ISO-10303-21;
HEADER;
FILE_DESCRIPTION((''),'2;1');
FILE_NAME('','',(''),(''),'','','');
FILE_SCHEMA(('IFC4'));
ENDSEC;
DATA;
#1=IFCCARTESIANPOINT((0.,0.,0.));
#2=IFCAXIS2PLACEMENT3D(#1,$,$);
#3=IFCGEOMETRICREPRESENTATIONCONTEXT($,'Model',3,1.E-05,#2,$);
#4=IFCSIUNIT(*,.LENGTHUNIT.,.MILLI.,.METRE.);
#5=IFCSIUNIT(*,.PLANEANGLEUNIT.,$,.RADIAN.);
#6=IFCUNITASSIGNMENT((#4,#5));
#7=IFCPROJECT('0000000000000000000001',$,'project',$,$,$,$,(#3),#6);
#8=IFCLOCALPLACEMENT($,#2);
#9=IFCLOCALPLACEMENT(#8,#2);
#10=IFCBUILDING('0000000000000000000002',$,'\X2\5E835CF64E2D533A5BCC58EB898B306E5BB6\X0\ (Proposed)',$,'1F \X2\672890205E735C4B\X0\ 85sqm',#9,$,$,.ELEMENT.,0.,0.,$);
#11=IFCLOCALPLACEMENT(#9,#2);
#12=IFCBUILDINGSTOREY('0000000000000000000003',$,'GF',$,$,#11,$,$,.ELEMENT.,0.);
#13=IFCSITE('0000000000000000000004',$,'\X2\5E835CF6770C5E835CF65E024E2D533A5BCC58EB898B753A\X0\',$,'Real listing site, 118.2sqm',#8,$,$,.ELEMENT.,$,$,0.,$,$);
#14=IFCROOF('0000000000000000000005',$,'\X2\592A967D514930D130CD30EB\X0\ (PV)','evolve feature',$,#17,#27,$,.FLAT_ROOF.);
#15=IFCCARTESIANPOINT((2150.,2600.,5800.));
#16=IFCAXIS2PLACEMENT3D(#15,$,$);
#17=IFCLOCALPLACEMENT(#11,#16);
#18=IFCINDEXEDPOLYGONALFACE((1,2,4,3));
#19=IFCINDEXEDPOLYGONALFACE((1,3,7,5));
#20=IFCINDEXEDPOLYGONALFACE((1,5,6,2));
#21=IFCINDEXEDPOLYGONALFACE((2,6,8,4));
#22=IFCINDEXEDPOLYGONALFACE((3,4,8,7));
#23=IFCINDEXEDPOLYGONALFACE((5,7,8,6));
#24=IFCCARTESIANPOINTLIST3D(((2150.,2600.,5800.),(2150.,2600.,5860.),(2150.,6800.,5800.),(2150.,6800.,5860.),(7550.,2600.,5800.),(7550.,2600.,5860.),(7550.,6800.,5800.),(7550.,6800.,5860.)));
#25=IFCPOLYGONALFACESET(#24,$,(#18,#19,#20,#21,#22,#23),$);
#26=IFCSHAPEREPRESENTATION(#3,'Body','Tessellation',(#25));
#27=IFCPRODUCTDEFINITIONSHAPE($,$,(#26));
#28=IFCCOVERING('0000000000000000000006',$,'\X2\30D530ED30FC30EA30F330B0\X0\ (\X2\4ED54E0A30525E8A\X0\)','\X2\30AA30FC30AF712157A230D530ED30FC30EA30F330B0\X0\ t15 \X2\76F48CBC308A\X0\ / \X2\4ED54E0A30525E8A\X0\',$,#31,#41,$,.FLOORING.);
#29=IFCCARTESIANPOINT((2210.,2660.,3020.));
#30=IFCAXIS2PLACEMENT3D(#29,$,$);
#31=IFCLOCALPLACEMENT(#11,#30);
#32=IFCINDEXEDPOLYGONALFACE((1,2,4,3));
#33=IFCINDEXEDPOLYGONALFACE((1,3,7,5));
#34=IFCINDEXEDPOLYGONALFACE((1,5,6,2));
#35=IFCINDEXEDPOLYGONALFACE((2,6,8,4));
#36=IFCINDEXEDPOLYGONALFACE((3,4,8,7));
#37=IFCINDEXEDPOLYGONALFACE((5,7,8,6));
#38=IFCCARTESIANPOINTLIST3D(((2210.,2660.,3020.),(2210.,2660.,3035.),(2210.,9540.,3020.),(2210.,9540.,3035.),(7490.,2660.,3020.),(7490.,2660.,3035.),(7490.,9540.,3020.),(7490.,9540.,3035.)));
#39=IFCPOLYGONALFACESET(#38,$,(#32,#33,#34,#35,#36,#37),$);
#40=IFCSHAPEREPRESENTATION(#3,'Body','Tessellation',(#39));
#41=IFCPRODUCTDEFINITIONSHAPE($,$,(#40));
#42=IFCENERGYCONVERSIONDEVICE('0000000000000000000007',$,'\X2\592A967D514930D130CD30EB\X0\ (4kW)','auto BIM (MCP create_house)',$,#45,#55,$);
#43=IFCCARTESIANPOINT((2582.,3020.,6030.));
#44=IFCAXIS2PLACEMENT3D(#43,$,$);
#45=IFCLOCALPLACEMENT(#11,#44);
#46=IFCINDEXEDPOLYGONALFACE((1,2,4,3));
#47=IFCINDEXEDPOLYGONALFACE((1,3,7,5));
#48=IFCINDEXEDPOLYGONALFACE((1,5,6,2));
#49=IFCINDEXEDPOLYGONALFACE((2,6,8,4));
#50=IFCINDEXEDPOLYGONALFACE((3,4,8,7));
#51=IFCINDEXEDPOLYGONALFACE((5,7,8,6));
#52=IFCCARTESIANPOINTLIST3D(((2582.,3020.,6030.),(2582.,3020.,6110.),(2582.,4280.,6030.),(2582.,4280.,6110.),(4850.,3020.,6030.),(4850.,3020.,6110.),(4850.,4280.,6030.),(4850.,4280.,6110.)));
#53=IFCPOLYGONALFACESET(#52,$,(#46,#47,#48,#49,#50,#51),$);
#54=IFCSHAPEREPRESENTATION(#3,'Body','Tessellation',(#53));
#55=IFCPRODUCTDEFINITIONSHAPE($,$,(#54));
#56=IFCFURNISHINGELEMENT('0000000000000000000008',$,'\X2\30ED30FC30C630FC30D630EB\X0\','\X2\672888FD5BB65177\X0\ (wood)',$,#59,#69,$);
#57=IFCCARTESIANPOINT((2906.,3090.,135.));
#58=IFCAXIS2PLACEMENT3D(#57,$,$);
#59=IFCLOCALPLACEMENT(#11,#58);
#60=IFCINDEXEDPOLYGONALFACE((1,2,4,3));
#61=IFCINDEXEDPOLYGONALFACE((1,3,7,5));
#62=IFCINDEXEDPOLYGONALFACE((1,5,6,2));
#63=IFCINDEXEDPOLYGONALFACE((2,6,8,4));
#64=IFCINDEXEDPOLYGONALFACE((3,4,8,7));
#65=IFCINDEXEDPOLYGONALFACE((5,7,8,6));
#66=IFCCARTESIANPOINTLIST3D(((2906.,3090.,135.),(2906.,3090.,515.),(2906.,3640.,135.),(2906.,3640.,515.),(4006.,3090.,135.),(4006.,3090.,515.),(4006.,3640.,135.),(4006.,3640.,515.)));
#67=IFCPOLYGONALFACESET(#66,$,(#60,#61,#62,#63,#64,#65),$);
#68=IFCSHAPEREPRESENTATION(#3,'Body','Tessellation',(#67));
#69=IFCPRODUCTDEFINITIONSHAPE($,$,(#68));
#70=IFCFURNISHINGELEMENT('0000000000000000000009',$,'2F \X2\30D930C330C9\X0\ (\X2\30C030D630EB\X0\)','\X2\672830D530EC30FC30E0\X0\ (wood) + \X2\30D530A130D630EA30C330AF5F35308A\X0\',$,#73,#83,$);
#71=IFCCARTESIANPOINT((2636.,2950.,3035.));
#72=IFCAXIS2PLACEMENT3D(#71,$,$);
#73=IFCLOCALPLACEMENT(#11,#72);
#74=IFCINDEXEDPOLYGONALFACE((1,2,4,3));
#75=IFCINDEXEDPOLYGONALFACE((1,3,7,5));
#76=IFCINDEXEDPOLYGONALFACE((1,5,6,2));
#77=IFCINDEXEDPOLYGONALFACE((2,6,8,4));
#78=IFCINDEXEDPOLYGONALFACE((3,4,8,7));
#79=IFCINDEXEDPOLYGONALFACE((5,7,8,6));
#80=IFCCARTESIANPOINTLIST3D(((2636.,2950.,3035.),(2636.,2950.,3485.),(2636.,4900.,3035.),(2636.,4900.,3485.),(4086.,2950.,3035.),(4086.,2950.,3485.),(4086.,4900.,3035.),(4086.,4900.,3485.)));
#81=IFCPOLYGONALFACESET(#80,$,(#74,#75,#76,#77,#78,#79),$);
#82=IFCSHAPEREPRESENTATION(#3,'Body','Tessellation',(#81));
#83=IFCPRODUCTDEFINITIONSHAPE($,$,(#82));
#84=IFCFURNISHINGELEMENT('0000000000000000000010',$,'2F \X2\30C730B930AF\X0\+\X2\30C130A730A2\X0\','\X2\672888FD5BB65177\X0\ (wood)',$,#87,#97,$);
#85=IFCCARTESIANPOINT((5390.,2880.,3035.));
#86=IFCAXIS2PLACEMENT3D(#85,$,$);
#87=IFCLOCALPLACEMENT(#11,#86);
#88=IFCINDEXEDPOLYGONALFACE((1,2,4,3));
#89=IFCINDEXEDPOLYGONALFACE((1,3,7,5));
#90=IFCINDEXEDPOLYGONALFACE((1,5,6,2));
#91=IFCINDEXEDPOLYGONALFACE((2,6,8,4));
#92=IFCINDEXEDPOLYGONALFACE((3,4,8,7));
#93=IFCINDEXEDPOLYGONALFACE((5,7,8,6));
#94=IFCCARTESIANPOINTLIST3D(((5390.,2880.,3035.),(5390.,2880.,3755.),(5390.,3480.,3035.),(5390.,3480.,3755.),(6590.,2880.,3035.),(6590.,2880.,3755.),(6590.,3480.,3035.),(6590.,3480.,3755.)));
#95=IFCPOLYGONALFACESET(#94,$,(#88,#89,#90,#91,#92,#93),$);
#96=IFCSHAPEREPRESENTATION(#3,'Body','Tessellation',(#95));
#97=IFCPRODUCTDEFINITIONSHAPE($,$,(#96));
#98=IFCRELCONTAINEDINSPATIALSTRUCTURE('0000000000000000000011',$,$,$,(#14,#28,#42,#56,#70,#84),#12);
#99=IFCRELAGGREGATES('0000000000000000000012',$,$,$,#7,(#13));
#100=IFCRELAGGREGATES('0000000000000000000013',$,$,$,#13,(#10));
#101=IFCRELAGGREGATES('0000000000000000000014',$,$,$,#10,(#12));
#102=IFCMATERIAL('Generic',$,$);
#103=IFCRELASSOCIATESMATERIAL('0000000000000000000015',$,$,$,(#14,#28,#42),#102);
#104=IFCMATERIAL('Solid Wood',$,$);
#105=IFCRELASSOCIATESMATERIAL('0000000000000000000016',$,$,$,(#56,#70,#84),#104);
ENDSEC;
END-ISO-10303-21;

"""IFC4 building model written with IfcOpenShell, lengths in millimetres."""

from ifc_helpers import new_model, si_unit, frame, frame_2d, origin, place, context, project, spatial, rectangle, extrude, material, element, save


model = new_model("IFC4")

# Units and contexts
model_context = context("Model", 3, precision=1e-05, world=origin())
ifc_project = project(units=[si_unit("LENGTHUNIT", "METRE", prefix="MILLI"), si_unit("PLANEANGLEUNIT", "RADIAN")], contexts=[model_context])

# Site, building, storey
site_placement = place(None, origin())
site = spatial("IfcSite", under=ifc_project, at=site_placement, Name="広島県広島市中区富士見町", ObjectType="Real listing site, 118.2sqm", CompositionType="ELEMENT", RefElevation=0.0)
building_placement = place(site_placement, origin())
building = spatial("IfcBuilding", under=site, at=building_placement, Name="広島中区富士見の家 (Proposed)", ObjectType="1F 木造平屋 85sqm", CompositionType="ELEMENT", ElevationOfRefHeight=0.0, ElevationOfTerrain=0.0)
storey_placement = place(building_placement, origin())
storey = spatial("IfcBuildingStorey", under=building, at=storey_placement, Name="GF", CompositionType="ELEMENT", Elevation=0.0)

# Shared definitions
ifc_material_1 = material(Name="Solid Wood")

# Shared definitions
ifc_material_2 = material(Name="Generic")

# Roof
roof_1_placement = place(storey_placement, frame((2150.0, 2600.0, 5800.0)))
element("IfcRoof", 1, at=roof_1_placement, inside=storey, material=ifc_material_2, Name="太陽光パネル (PV)", Description="evolve feature", PredefinedType="FLAT_ROOF", context=model_context, shape_type="SweptSolid", body=[
    extrude(rectangle(XDim=5400.0, YDim=4200.0, at=frame_2d((2700.0, 2100.0))), frame((2150.0, 2600.0, 5800.0)), (0.0, 0.0, 1.0), 60.0),
])

# Covering
covering_placement = place(storey_placement, frame((2210.0, 2660.0, 3020.0)))
element("IfcCovering", 2, at=covering_placement, inside=storey, material=ifc_material_2, Name="フローリング (仕上げ床)", Description="オーク無垢フローリング t15 直貼り / 仕上げ床", PredefinedType="FLOORING", context=model_context, shape_type="SweptSolid", body=[
    extrude(rectangle(XDim=5280.0, YDim=6880.0, at=frame_2d((2640.0, 3440.0))), frame((2210.0, 2660.0, 3020.0)), (0.0, 0.0, 1.0), 15.0),
])

# Energy conversion device
energy_conversion_device_placement = place(storey_placement, frame((2582.0, 3020.0, 6030.0)))
element("IfcEnergyConversionDevice", 3, at=energy_conversion_device_placement, inside=storey, material=ifc_material_2, Name="太陽光パネル (4kW)", Description="auto BIM (MCP create_house)", context=model_context, shape_type="SweptSolid", body=[
    extrude(rectangle(XDim=2268.0, YDim=1260.0, at=frame_2d((1134.0, 630.0))), frame((2582.0, 3020.0, 6030.0)), (0.0, 0.0, 1.0), 80.0),
])

# Furnishing elements
furnishing_1_placement = place(storey_placement, frame((2906.0, 3090.0, 135.0)))
element("IfcFurnishingElement", 4, at=furnishing_1_placement, inside=storey, material=ifc_material_1, Name="ローテーブル", Description="木製家具 (wood)", context=model_context, shape_type="SweptSolid", body=[
    extrude(rectangle(XDim=1100.0, YDim=550.0, at=frame_2d((550.0, 275.0))), frame((2906.0, 3090.0, 135.0)), (0.0, 0.0, 1.0), 380.0),
])
furnishing_2_placement = place(storey_placement, frame((2636.0, 2950.0, 3035.0)))
element("IfcFurnishingElement", 5, at=furnishing_2_placement, inside=storey, material=ifc_material_1, Name="2F ベッド (ダブル)", Description="木フレーム (wood) + ファブリック張り", context=model_context, shape_type="SweptSolid", body=[
    extrude(rectangle(XDim=1450.0, YDim=1950.0, at=frame_2d((725.0, 975.0))), frame((2636.0, 2950.0, 3035.0)), (0.0, 0.0, 1.0), 450.0),
])
furnishing_3_placement = place(storey_placement, frame((5390.0, 2880.0, 3035.0)))
element("IfcFurnishingElement", 6, at=furnishing_3_placement, inside=storey, material=ifc_material_1, Name="2F デスク+チェア", Description="木製家具 (wood)", context=model_context, shape_type="SweptSolid", body=[
    extrude(rectangle(XDim=1200.0, YDim=600.0, at=frame_2d((600.0, 300.0))), frame((5390.0, 2880.0, 3035.0)), (0.0, 0.0, 1.0), 720.0),
])

save(model, "model.ifc")
